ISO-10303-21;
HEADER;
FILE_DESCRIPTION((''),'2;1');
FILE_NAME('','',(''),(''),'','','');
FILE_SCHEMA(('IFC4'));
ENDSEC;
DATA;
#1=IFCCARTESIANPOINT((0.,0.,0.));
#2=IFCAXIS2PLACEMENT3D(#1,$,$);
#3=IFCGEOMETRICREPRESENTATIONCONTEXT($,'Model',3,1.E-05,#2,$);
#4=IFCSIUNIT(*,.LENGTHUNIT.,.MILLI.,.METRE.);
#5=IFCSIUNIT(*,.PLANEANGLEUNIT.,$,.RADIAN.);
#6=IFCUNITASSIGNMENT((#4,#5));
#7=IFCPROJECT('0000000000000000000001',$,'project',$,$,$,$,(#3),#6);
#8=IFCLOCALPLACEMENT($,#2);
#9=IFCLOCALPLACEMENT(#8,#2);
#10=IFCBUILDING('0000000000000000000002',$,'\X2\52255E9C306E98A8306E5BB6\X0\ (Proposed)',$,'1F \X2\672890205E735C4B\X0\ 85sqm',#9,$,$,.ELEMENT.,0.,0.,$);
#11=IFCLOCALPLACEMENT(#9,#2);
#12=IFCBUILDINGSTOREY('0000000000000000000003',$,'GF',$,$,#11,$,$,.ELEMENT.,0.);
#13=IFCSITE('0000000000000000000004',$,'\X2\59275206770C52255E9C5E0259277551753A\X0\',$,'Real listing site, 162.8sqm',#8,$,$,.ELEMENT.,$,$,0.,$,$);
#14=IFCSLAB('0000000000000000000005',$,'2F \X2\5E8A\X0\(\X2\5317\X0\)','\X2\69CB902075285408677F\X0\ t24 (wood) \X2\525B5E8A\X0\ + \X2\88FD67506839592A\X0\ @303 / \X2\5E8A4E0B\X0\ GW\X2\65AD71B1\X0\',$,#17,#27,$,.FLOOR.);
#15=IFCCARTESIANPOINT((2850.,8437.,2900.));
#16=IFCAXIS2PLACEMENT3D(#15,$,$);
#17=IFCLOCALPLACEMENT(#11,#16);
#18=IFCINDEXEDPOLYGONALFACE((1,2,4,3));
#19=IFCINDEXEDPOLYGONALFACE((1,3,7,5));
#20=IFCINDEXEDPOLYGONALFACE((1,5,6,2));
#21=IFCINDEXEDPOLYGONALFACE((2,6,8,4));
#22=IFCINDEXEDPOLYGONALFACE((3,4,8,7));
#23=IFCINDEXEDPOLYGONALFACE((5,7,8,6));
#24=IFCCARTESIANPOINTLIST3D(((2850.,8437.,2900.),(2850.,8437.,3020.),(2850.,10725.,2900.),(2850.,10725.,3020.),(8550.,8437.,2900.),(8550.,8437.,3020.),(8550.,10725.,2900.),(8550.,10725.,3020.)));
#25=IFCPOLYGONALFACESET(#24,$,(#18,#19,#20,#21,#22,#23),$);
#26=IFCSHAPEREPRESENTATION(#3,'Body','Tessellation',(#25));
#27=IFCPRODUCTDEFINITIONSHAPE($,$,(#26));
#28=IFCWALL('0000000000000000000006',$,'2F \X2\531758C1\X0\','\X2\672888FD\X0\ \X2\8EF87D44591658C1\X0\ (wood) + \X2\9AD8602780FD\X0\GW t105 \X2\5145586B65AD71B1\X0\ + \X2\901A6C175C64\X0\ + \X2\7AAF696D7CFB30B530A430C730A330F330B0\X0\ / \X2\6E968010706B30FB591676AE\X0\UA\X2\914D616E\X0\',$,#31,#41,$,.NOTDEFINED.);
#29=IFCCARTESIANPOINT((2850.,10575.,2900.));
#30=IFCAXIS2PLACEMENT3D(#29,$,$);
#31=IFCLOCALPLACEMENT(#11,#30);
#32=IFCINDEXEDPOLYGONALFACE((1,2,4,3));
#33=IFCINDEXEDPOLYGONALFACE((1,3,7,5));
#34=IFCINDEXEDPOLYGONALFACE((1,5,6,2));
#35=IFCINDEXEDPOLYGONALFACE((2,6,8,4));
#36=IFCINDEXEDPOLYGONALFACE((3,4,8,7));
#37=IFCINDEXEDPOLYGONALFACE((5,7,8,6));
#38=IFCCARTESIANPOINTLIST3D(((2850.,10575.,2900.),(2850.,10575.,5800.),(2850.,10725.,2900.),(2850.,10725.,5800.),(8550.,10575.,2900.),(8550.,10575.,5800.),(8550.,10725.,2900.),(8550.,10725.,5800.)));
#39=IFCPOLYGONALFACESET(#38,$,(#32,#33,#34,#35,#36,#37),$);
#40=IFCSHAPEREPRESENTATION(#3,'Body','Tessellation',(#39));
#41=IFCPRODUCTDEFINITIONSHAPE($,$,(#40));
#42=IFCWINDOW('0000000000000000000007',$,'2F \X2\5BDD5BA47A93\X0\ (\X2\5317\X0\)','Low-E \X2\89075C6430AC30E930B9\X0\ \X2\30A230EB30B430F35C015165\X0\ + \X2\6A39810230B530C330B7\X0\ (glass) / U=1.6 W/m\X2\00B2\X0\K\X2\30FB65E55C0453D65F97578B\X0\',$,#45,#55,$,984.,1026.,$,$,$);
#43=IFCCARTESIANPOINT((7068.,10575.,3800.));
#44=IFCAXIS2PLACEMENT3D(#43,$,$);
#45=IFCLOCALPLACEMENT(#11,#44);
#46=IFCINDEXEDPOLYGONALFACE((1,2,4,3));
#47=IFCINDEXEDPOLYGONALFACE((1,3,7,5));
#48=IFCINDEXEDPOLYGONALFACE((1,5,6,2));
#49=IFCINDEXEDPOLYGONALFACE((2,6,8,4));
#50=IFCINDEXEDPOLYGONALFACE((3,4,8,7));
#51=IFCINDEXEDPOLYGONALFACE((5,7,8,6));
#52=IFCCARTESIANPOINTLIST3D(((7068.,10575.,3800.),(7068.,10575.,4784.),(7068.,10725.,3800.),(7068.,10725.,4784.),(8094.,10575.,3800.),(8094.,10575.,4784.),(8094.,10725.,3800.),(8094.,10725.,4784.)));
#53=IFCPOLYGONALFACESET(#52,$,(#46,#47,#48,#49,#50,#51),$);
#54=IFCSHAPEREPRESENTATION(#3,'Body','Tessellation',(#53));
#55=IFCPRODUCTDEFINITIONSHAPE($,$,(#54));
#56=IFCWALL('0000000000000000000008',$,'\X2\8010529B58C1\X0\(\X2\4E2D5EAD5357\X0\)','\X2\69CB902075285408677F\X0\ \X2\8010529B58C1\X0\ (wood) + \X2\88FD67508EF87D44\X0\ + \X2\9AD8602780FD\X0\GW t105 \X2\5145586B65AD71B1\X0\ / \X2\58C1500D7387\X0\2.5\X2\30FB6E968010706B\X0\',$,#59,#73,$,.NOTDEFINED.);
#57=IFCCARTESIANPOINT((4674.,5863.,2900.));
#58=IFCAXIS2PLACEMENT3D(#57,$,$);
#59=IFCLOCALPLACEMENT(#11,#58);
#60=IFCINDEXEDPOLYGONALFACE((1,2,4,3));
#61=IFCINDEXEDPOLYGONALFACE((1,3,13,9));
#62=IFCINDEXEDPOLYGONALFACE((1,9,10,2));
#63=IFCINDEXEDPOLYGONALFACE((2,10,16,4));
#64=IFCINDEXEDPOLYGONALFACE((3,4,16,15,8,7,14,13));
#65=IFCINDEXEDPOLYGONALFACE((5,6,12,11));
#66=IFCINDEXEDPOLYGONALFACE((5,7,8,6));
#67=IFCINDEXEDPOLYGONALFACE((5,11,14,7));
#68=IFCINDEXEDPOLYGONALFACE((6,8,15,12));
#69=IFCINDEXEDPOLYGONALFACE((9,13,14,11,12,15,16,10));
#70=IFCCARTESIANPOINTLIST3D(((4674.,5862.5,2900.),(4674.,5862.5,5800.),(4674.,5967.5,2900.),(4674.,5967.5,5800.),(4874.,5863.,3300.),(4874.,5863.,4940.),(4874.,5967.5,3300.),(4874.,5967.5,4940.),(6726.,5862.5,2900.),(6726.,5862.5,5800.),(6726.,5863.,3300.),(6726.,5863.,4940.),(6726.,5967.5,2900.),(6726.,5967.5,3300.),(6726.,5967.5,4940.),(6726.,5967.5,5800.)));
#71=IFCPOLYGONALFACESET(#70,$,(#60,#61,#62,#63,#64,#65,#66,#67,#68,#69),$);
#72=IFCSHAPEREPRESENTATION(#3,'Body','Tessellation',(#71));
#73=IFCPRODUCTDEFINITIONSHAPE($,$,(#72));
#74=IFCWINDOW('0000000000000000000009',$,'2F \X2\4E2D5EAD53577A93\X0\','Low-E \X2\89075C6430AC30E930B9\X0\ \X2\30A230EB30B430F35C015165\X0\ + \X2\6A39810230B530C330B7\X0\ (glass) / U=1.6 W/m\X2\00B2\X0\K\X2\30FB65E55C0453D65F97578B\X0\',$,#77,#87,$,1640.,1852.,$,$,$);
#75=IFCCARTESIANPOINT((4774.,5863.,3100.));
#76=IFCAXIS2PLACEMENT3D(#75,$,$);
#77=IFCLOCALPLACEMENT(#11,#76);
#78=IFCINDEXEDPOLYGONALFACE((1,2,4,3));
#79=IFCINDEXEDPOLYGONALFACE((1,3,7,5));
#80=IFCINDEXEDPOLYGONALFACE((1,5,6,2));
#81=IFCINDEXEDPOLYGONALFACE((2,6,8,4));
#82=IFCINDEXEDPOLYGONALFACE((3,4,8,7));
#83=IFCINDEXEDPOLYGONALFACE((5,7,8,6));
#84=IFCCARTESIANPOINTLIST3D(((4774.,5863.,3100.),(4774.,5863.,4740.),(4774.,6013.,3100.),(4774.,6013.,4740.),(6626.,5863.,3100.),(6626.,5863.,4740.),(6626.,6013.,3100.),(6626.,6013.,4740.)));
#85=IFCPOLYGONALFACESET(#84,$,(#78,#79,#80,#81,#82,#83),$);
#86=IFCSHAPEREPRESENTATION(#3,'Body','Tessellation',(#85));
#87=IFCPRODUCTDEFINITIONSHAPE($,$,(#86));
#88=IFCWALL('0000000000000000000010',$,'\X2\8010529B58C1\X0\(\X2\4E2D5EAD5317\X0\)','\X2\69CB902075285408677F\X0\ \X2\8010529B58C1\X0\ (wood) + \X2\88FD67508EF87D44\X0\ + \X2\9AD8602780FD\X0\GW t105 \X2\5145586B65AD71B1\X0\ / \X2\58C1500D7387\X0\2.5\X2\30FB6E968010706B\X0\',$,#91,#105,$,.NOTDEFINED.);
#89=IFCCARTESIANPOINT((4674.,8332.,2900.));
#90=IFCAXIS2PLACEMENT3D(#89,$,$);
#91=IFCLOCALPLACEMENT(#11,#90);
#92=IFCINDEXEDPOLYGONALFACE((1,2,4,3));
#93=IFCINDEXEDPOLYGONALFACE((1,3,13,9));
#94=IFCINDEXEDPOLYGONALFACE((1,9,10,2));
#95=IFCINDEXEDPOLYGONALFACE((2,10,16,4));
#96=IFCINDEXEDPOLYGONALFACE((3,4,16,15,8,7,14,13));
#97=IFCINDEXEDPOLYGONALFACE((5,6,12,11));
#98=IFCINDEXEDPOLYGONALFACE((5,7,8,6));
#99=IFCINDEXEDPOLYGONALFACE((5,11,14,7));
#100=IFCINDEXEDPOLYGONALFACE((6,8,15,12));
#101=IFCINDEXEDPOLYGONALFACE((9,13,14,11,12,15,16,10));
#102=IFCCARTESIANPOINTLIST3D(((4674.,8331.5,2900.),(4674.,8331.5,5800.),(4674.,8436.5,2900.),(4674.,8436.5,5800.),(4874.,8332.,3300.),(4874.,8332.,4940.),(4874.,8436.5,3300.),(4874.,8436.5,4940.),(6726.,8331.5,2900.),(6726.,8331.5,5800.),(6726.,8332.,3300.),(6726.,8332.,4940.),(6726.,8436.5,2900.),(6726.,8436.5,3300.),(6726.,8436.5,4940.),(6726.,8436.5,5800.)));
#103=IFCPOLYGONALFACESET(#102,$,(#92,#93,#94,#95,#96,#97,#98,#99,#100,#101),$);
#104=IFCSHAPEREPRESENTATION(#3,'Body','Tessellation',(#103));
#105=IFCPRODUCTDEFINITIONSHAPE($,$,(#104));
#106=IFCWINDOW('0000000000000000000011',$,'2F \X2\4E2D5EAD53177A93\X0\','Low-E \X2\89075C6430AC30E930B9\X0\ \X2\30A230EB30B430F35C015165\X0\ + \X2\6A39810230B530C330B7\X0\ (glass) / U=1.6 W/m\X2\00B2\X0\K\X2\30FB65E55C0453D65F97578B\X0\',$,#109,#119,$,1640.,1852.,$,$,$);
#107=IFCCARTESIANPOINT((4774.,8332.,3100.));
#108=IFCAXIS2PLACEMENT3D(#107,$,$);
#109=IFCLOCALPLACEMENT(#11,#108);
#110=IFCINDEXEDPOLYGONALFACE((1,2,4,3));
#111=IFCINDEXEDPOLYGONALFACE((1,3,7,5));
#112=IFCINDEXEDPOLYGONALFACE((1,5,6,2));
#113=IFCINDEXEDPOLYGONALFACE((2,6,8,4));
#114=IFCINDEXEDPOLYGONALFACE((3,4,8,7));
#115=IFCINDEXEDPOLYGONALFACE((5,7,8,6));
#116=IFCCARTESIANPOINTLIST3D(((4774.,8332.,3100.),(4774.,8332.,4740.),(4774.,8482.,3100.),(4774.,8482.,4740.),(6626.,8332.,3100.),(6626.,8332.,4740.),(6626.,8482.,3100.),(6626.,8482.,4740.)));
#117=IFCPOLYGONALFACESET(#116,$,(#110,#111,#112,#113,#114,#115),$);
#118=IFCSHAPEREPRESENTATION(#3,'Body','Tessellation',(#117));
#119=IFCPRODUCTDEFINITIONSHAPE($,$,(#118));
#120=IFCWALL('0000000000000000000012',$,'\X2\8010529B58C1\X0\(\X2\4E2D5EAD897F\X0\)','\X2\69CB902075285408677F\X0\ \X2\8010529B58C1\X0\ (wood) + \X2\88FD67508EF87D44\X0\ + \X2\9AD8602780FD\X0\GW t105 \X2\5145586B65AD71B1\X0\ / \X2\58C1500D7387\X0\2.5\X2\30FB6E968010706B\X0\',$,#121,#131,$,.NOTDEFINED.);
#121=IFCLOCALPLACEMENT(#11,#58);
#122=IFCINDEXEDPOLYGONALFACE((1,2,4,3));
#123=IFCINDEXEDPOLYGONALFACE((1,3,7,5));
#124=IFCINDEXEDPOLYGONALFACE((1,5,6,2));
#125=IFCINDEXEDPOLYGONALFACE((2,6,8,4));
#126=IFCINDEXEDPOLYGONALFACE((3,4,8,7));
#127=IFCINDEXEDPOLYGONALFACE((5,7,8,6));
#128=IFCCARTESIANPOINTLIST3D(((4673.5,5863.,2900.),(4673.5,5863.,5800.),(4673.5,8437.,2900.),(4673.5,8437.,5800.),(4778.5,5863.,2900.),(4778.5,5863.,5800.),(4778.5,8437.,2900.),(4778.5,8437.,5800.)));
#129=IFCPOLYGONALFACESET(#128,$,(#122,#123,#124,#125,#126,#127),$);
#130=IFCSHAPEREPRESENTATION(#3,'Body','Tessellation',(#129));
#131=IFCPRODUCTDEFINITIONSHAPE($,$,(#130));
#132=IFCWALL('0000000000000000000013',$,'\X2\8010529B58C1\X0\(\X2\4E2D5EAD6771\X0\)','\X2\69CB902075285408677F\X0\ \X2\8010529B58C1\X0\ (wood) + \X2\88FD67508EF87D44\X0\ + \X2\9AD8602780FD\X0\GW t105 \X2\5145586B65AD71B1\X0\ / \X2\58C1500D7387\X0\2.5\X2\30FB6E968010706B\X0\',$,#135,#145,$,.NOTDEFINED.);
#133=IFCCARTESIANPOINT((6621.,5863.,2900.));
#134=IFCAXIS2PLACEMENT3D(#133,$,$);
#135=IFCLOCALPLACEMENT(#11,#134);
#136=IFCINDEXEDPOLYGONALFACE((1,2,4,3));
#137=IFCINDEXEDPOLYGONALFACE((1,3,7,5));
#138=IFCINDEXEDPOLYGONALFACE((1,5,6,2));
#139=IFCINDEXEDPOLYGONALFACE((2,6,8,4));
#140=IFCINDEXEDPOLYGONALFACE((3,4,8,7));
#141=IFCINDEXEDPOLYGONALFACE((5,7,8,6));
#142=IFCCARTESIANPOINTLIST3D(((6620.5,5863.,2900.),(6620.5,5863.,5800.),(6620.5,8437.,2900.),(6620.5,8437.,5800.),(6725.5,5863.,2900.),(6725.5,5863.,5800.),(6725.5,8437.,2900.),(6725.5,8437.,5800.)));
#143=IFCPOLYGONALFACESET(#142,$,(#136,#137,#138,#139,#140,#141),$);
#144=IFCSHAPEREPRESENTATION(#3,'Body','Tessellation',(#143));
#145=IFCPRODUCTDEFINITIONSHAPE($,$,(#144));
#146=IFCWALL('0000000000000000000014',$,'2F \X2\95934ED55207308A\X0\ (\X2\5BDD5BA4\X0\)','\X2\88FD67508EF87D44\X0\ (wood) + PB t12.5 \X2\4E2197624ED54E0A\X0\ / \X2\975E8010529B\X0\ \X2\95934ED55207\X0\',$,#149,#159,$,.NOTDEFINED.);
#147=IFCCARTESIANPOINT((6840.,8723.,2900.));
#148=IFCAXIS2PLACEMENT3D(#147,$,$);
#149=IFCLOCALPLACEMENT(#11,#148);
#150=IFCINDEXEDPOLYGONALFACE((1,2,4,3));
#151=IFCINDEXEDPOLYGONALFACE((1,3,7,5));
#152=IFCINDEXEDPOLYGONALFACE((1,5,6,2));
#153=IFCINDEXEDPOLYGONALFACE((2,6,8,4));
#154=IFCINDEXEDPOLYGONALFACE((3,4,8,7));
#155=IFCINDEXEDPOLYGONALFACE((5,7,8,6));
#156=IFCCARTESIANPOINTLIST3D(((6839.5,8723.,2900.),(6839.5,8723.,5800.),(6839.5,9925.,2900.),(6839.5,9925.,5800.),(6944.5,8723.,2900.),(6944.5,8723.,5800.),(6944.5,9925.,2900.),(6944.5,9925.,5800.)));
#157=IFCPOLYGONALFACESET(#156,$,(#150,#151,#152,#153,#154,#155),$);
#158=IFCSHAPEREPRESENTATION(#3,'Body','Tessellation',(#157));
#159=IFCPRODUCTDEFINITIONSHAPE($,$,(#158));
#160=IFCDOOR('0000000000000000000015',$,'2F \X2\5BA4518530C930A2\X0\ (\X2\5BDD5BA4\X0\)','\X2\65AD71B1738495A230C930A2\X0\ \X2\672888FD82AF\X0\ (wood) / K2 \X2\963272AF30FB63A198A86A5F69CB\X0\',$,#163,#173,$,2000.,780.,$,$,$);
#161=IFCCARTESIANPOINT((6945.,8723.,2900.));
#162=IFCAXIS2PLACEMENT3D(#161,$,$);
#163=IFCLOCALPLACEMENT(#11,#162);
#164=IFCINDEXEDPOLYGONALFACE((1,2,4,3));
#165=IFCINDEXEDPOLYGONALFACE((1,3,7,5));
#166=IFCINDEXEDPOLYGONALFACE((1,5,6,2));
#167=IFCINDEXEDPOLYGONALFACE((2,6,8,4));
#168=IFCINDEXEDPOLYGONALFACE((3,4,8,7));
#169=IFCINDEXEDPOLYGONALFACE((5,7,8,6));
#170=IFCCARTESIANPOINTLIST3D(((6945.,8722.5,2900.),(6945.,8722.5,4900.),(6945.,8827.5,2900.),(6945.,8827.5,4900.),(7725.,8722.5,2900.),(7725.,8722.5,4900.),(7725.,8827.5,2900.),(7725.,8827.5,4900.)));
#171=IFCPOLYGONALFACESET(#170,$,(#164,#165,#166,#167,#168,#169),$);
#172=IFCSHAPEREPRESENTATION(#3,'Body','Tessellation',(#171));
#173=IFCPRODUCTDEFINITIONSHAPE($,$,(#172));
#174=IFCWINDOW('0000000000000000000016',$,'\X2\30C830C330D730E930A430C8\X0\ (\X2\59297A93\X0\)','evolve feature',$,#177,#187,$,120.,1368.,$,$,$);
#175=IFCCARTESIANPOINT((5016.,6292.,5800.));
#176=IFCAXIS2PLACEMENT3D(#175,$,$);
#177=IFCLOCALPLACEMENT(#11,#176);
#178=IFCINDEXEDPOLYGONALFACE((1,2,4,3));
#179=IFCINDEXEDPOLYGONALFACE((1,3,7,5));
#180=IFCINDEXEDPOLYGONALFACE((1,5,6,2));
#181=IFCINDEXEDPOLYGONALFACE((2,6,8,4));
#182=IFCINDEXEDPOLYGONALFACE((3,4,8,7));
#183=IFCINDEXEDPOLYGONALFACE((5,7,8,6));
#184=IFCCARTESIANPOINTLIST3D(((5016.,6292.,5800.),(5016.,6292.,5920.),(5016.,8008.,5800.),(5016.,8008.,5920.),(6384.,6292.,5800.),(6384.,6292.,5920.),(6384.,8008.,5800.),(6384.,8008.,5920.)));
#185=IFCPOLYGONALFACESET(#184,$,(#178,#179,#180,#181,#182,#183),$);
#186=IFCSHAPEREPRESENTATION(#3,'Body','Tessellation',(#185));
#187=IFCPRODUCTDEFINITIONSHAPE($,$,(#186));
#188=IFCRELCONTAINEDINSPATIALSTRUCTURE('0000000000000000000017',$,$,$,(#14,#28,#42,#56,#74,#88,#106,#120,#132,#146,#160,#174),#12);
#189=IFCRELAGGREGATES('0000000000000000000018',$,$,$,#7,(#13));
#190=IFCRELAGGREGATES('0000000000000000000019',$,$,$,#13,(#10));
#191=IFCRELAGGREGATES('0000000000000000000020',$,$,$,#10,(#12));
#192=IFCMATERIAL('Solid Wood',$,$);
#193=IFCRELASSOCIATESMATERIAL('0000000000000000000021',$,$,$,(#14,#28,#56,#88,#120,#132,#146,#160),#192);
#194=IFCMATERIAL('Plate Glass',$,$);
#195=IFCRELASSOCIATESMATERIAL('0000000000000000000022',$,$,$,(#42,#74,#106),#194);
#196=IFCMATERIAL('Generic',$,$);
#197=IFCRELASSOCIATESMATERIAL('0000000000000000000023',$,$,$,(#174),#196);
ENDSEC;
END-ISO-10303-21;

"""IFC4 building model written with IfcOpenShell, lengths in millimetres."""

from ifc_helpers import new_model, si_unit, frame, frame_2d, origin, place, context, project, spatial, rectangle, extrude, material, element, fill, save


model = new_model("IFC4")

# Units and contexts
model_context = context("Model", 3, precision=1e-05, world=origin())
ifc_project = project(units=[si_unit("LENGTHUNIT", "METRE", prefix="MILLI"), si_unit("PLANEANGLEUNIT", "RADIAN")], contexts=[model_context])

# Site, building, storey
site_placement = place(None, origin())
site = spatial("IfcSite", under=ifc_project, at=site_placement, Name="大分県別府市大畑町", ObjectType="Real listing site, 162.8sqm", CompositionType="ELEMENT", RefElevation=0.0)
building_placement = place(site_placement, origin())
building = spatial("IfcBuilding", under=site, at=building_placement, Name="別府の風の家 (Proposed)", ObjectType="1F 木造平屋 85sqm", CompositionType="ELEMENT", ElevationOfRefHeight=0.0, ElevationOfTerrain=0.0)
storey_placement = place(building_placement, origin())
storey = spatial("IfcBuildingStorey", under=building, at=storey_placement, Name="GF", CompositionType="ELEMENT", Elevation=0.0)

# Slab
ifc_material_1 = material(Name="Solid Wood")
slab_placement = place(storey_placement, frame((2850.0, 8437.0, 2900.0)))
element("IfcSlab", 1, at=slab_placement, inside=storey, material=ifc_material_1, Name="2F 床(北)", Description="構造用合板 t24 (wood) 剛床 + 製材根太 @303 / 床下 GW断熱", PredefinedType="FLOOR", context=model_context, shape_type="SweptSolid", body=[
    extrude(rectangle(XDim=5700.0, YDim=2288.0, at=frame_2d((2850.0, 1144.0))), frame((2850.0, 8437.0, 2900.0)), (0.0, 0.0, 1.0), 120.0),
])

# Walls, openings, windows
wall_1_placement = place(storey_placement, frame((2850.0, 10575.0, 2900.0)))
wall_1 = element("IfcWall", 2, at=wall_1_placement, inside=storey, material=ifc_material_1, Name="2F 北壁", Description="木製 軸組外壁 (wood) + 高性能GW t105 充填断熱 + 通気層 + 窯業系サイディング / 準耐火・外皮UA配慮", PredefinedType="NOTDEFINED", context=model_context, shape_type="SweptSolid", body=[
    extrude(rectangle(XDim=5700.0, YDim=150.0, at=frame_2d((2850.0, 75.0))), frame((2850.0, 10575.0, 2900.0)), (0.0, 0.0, 1.0), 2900.0),
])
opening_1_placement = place(storey_placement, frame((7068.0, 10575.0, 3800.0)))
opening_1 = element("IfcOpeningElement", 3, at=opening_1_placement, cuts=wall_1, PredefinedType="NOTDEFINED", context=model_context, shape_type="SweptSolid", body=[
    extrude(rectangle(XDim=1026.0, YDim=150.0, at=frame_2d((513.0, 75.0))), frame((7068.0, 10575.0, 3800.0)), (0.0, 0.0, 1.0), 984.0),
])
ifc_material_2 = material(Name="Plate Glass")
window_1_placement = place(storey_placement, frame((7068.0, 10575.0, 3800.0)))
window_1 = element("IfcWindow", 4, at=window_1_placement, inside=storey, material=ifc_material_2, Name="2F 寝室窓 (北)", Description="Low-E 複層ガラス アルゴン封入 + 樹脂サッシ (glass) / U=1.6 W/m²K・日射取得型", OverallHeight=984.0, OverallWidth=1026.0, context=model_context, shape_type="SweptSolid", body=[
    extrude(rectangle(XDim=1026.0, YDim=150.0, at=frame_2d((513.0, 75.0))), frame((7068.0, 10575.0, 3800.0)), (0.0, 0.0, 1.0), 984.0),
])
fill(opening_1, window_1)
wall_2_placement = place(storey_placement, frame((4674.0, 5863.0, 2900.0)))
wall_2 = element("IfcWall", 5, at=wall_2_placement, inside=storey, material=ifc_material_1, Name="耐力壁(中庭南)", Description="構造用合板 耐力壁 (wood) + 製材軸組 + 高性能GW t105 充填断熱 / 壁倍率2.5・準耐火", PredefinedType="NOTDEFINED", context=model_context, shape_type="SweptSolid", body=[
    extrude(rectangle(XDim=2052.0, YDim=105.0, at=frame_2d((1026.0, 52.0))), frame((4674.0, 5863.0, 2900.0)), (0.0, 0.0, 1.0), 2900.0),
])
opening_2_placement = place(storey_placement, frame((4774.0, 5863.0, 3100.0)))
opening_2 = element("IfcOpeningElement", 6, at=opening_2_placement, cuts=wall_2, PredefinedType="NOTDEFINED", context=model_context, shape_type="SweptSolid", body=[
    extrude(rectangle(XDim=1852.0, YDim=150.0, at=frame_2d((926.0, 75.0))), frame((4774.0, 5863.0, 3100.0)), (0.0, 0.0, 1.0), 1640.0),
])
window_2_placement = place(storey_placement, frame((4774.0, 5863.0, 3100.0)))
window_2 = element("IfcWindow", 7, at=window_2_placement, inside=storey, material=ifc_material_2, Name="2F 中庭南窓", Description="Low-E 複層ガラス アルゴン封入 + 樹脂サッシ (glass) / U=1.6 W/m²K・日射取得型", OverallHeight=1640.0, OverallWidth=1852.0, context=model_context, shape_type="SweptSolid", body=[
    extrude(rectangle(XDim=1852.0, YDim=150.0, at=frame_2d((926.0, 75.0))), frame((4774.0, 5863.0, 3100.0)), (0.0, 0.0, 1.0), 1640.0),
])
fill(opening_2, window_2)
wall_3_placement = place(storey_placement, frame((4674.0, 8332.0, 2900.0)))
wall_3 = element("IfcWall", 8, at=wall_3_placement, inside=storey, material=ifc_material_1, Name="耐力壁(中庭北)", Description="構造用合板 耐力壁 (wood) + 製材軸組 + 高性能GW t105 充填断熱 / 壁倍率2.5・準耐火", PredefinedType="NOTDEFINED", context=model_context, shape_type="SweptSolid", body=[
    extrude(rectangle(XDim=2052.0, YDim=105.0, at=frame_2d((1026.0, 52.0))), frame((4674.0, 8332.0, 2900.0)), (0.0, 0.0, 1.0), 2900.0),
])
opening_3_placement = place(storey_placement, frame((4774.0, 8332.0, 3100.0)))
opening_3 = element("IfcOpeningElement", 9, at=opening_3_placement, cuts=wall_3, PredefinedType="NOTDEFINED", context=model_context, shape_type="SweptSolid", body=[
    extrude(rectangle(XDim=1852.0, YDim=150.0, at=frame_2d((926.0, 75.0))), frame((4774.0, 8332.0, 3100.0)), (0.0, 0.0, 1.0), 1640.0),
])
window_3_placement = place(storey_placement, frame((4774.0, 8332.0, 3100.0)))
window_3 = element("IfcWindow", 10, at=window_3_placement, inside=storey, material=ifc_material_2, Name="2F 中庭北窓", Description="Low-E 複層ガラス アルゴン封入 + 樹脂サッシ (glass) / U=1.6 W/m²K・日射取得型", OverallHeight=1640.0, OverallWidth=1852.0, context=model_context, shape_type="SweptSolid", body=[
    extrude(rectangle(XDim=1852.0, YDim=150.0, at=frame_2d((926.0, 75.0))), frame((4774.0, 8332.0, 3100.0)), (0.0, 0.0, 1.0), 1640.0),
])
fill(opening_3, window_3)

# Walls
wall_4_placement = place(storey_placement, frame((4674.0, 5863.0, 2900.0)))
element("IfcWall", 11, at=wall_4_placement, inside=storey, material=ifc_material_1, Name="耐力壁(中庭西)", Description="構造用合板 耐力壁 (wood) + 製材軸組 + 高性能GW t105 充填断熱 / 壁倍率2.5・準耐火", PredefinedType="NOTDEFINED", context=model_context, shape_type="SweptSolid", body=[
    extrude(rectangle(XDim=105.0, YDim=2574.0, at=frame_2d((52.0, 1287.0))), frame((4674.0, 5863.0, 2900.0)), (0.0, 0.0, 1.0), 2900.0),
])
wall_5_placement = place(storey_placement, frame((6621.0, 5863.0, 2900.0)))
element("IfcWall", 12, at=wall_5_placement, inside=storey, material=ifc_material_1, Name="耐力壁(中庭東)", Description="構造用合板 耐力壁 (wood) + 製材軸組 + 高性能GW t105 充填断熱 / 壁倍率2.5・準耐火", PredefinedType="NOTDEFINED", context=model_context, shape_type="SweptSolid", body=[
    extrude(rectangle(XDim=105.0, YDim=2574.0, at=frame_2d((52.0, 1287.0))), frame((6621.0, 5863.0, 2900.0)), (0.0, 0.0, 1.0), 2900.0),
])
wall_6_placement = place(storey_placement, frame((6840.0, 8723.0, 2900.0)))
element("IfcWall", 13, at=wall_6_placement, inside=storey, material=ifc_material_1, Name="2F 間仕切り (寝室)", Description="製材軸組 (wood) + PB t12.5 両面仕上 / 非耐力 間仕切", PredefinedType="NOTDEFINED", context=model_context, shape_type="SweptSolid", body=[
    extrude(rectangle(XDim=105.0, YDim=1202.0, at=frame_2d((52.0, 601.0))), frame((6840.0, 8723.0, 2900.0)), (0.0, 0.0, 1.0), 2900.0),
])

# Door
door_placement = place(storey_placement, frame((6945.0, 8723.0, 2900.0)))
element("IfcDoor", 14, at=door_placement, inside=storey, material=ifc_material_1, Name="2F 室内ドア (寝室)", Description="断熱玄関ドア 木製芯 (wood) / K2 防犯・採風機構", OverallHeight=2000.0, OverallWidth=780.0, context=model_context, shape_type="SweptSolid", body=[
    extrude(rectangle(XDim=780.0, YDim=105.0, at=frame_2d((390.0, 52.0))), frame((6945.0, 8723.0, 2900.0)), (0.0, 0.0, 1.0), 2000.0),
])

# Window
ifc_material_3 = material(Name="Generic")
window_4_placement = place(storey_placement, frame((5016.0, 6292.0, 5800.0)))
element("IfcWindow", 15, at=window_4_placement, inside=storey, material=ifc_material_3, Name="トップライト (天窓)", Description="evolve feature", OverallHeight=120.0, OverallWidth=1368.0, context=model_context, shape_type="SweptSolid", body=[
    extrude(rectangle(XDim=1368.0, YDim=1716.0, at=frame_2d((684.0, 858.0))), frame((5016.0, 6292.0, 5800.0)), (0.0, 0.0, 1.0), 120.0),
])

save(model, "model.ifc")
